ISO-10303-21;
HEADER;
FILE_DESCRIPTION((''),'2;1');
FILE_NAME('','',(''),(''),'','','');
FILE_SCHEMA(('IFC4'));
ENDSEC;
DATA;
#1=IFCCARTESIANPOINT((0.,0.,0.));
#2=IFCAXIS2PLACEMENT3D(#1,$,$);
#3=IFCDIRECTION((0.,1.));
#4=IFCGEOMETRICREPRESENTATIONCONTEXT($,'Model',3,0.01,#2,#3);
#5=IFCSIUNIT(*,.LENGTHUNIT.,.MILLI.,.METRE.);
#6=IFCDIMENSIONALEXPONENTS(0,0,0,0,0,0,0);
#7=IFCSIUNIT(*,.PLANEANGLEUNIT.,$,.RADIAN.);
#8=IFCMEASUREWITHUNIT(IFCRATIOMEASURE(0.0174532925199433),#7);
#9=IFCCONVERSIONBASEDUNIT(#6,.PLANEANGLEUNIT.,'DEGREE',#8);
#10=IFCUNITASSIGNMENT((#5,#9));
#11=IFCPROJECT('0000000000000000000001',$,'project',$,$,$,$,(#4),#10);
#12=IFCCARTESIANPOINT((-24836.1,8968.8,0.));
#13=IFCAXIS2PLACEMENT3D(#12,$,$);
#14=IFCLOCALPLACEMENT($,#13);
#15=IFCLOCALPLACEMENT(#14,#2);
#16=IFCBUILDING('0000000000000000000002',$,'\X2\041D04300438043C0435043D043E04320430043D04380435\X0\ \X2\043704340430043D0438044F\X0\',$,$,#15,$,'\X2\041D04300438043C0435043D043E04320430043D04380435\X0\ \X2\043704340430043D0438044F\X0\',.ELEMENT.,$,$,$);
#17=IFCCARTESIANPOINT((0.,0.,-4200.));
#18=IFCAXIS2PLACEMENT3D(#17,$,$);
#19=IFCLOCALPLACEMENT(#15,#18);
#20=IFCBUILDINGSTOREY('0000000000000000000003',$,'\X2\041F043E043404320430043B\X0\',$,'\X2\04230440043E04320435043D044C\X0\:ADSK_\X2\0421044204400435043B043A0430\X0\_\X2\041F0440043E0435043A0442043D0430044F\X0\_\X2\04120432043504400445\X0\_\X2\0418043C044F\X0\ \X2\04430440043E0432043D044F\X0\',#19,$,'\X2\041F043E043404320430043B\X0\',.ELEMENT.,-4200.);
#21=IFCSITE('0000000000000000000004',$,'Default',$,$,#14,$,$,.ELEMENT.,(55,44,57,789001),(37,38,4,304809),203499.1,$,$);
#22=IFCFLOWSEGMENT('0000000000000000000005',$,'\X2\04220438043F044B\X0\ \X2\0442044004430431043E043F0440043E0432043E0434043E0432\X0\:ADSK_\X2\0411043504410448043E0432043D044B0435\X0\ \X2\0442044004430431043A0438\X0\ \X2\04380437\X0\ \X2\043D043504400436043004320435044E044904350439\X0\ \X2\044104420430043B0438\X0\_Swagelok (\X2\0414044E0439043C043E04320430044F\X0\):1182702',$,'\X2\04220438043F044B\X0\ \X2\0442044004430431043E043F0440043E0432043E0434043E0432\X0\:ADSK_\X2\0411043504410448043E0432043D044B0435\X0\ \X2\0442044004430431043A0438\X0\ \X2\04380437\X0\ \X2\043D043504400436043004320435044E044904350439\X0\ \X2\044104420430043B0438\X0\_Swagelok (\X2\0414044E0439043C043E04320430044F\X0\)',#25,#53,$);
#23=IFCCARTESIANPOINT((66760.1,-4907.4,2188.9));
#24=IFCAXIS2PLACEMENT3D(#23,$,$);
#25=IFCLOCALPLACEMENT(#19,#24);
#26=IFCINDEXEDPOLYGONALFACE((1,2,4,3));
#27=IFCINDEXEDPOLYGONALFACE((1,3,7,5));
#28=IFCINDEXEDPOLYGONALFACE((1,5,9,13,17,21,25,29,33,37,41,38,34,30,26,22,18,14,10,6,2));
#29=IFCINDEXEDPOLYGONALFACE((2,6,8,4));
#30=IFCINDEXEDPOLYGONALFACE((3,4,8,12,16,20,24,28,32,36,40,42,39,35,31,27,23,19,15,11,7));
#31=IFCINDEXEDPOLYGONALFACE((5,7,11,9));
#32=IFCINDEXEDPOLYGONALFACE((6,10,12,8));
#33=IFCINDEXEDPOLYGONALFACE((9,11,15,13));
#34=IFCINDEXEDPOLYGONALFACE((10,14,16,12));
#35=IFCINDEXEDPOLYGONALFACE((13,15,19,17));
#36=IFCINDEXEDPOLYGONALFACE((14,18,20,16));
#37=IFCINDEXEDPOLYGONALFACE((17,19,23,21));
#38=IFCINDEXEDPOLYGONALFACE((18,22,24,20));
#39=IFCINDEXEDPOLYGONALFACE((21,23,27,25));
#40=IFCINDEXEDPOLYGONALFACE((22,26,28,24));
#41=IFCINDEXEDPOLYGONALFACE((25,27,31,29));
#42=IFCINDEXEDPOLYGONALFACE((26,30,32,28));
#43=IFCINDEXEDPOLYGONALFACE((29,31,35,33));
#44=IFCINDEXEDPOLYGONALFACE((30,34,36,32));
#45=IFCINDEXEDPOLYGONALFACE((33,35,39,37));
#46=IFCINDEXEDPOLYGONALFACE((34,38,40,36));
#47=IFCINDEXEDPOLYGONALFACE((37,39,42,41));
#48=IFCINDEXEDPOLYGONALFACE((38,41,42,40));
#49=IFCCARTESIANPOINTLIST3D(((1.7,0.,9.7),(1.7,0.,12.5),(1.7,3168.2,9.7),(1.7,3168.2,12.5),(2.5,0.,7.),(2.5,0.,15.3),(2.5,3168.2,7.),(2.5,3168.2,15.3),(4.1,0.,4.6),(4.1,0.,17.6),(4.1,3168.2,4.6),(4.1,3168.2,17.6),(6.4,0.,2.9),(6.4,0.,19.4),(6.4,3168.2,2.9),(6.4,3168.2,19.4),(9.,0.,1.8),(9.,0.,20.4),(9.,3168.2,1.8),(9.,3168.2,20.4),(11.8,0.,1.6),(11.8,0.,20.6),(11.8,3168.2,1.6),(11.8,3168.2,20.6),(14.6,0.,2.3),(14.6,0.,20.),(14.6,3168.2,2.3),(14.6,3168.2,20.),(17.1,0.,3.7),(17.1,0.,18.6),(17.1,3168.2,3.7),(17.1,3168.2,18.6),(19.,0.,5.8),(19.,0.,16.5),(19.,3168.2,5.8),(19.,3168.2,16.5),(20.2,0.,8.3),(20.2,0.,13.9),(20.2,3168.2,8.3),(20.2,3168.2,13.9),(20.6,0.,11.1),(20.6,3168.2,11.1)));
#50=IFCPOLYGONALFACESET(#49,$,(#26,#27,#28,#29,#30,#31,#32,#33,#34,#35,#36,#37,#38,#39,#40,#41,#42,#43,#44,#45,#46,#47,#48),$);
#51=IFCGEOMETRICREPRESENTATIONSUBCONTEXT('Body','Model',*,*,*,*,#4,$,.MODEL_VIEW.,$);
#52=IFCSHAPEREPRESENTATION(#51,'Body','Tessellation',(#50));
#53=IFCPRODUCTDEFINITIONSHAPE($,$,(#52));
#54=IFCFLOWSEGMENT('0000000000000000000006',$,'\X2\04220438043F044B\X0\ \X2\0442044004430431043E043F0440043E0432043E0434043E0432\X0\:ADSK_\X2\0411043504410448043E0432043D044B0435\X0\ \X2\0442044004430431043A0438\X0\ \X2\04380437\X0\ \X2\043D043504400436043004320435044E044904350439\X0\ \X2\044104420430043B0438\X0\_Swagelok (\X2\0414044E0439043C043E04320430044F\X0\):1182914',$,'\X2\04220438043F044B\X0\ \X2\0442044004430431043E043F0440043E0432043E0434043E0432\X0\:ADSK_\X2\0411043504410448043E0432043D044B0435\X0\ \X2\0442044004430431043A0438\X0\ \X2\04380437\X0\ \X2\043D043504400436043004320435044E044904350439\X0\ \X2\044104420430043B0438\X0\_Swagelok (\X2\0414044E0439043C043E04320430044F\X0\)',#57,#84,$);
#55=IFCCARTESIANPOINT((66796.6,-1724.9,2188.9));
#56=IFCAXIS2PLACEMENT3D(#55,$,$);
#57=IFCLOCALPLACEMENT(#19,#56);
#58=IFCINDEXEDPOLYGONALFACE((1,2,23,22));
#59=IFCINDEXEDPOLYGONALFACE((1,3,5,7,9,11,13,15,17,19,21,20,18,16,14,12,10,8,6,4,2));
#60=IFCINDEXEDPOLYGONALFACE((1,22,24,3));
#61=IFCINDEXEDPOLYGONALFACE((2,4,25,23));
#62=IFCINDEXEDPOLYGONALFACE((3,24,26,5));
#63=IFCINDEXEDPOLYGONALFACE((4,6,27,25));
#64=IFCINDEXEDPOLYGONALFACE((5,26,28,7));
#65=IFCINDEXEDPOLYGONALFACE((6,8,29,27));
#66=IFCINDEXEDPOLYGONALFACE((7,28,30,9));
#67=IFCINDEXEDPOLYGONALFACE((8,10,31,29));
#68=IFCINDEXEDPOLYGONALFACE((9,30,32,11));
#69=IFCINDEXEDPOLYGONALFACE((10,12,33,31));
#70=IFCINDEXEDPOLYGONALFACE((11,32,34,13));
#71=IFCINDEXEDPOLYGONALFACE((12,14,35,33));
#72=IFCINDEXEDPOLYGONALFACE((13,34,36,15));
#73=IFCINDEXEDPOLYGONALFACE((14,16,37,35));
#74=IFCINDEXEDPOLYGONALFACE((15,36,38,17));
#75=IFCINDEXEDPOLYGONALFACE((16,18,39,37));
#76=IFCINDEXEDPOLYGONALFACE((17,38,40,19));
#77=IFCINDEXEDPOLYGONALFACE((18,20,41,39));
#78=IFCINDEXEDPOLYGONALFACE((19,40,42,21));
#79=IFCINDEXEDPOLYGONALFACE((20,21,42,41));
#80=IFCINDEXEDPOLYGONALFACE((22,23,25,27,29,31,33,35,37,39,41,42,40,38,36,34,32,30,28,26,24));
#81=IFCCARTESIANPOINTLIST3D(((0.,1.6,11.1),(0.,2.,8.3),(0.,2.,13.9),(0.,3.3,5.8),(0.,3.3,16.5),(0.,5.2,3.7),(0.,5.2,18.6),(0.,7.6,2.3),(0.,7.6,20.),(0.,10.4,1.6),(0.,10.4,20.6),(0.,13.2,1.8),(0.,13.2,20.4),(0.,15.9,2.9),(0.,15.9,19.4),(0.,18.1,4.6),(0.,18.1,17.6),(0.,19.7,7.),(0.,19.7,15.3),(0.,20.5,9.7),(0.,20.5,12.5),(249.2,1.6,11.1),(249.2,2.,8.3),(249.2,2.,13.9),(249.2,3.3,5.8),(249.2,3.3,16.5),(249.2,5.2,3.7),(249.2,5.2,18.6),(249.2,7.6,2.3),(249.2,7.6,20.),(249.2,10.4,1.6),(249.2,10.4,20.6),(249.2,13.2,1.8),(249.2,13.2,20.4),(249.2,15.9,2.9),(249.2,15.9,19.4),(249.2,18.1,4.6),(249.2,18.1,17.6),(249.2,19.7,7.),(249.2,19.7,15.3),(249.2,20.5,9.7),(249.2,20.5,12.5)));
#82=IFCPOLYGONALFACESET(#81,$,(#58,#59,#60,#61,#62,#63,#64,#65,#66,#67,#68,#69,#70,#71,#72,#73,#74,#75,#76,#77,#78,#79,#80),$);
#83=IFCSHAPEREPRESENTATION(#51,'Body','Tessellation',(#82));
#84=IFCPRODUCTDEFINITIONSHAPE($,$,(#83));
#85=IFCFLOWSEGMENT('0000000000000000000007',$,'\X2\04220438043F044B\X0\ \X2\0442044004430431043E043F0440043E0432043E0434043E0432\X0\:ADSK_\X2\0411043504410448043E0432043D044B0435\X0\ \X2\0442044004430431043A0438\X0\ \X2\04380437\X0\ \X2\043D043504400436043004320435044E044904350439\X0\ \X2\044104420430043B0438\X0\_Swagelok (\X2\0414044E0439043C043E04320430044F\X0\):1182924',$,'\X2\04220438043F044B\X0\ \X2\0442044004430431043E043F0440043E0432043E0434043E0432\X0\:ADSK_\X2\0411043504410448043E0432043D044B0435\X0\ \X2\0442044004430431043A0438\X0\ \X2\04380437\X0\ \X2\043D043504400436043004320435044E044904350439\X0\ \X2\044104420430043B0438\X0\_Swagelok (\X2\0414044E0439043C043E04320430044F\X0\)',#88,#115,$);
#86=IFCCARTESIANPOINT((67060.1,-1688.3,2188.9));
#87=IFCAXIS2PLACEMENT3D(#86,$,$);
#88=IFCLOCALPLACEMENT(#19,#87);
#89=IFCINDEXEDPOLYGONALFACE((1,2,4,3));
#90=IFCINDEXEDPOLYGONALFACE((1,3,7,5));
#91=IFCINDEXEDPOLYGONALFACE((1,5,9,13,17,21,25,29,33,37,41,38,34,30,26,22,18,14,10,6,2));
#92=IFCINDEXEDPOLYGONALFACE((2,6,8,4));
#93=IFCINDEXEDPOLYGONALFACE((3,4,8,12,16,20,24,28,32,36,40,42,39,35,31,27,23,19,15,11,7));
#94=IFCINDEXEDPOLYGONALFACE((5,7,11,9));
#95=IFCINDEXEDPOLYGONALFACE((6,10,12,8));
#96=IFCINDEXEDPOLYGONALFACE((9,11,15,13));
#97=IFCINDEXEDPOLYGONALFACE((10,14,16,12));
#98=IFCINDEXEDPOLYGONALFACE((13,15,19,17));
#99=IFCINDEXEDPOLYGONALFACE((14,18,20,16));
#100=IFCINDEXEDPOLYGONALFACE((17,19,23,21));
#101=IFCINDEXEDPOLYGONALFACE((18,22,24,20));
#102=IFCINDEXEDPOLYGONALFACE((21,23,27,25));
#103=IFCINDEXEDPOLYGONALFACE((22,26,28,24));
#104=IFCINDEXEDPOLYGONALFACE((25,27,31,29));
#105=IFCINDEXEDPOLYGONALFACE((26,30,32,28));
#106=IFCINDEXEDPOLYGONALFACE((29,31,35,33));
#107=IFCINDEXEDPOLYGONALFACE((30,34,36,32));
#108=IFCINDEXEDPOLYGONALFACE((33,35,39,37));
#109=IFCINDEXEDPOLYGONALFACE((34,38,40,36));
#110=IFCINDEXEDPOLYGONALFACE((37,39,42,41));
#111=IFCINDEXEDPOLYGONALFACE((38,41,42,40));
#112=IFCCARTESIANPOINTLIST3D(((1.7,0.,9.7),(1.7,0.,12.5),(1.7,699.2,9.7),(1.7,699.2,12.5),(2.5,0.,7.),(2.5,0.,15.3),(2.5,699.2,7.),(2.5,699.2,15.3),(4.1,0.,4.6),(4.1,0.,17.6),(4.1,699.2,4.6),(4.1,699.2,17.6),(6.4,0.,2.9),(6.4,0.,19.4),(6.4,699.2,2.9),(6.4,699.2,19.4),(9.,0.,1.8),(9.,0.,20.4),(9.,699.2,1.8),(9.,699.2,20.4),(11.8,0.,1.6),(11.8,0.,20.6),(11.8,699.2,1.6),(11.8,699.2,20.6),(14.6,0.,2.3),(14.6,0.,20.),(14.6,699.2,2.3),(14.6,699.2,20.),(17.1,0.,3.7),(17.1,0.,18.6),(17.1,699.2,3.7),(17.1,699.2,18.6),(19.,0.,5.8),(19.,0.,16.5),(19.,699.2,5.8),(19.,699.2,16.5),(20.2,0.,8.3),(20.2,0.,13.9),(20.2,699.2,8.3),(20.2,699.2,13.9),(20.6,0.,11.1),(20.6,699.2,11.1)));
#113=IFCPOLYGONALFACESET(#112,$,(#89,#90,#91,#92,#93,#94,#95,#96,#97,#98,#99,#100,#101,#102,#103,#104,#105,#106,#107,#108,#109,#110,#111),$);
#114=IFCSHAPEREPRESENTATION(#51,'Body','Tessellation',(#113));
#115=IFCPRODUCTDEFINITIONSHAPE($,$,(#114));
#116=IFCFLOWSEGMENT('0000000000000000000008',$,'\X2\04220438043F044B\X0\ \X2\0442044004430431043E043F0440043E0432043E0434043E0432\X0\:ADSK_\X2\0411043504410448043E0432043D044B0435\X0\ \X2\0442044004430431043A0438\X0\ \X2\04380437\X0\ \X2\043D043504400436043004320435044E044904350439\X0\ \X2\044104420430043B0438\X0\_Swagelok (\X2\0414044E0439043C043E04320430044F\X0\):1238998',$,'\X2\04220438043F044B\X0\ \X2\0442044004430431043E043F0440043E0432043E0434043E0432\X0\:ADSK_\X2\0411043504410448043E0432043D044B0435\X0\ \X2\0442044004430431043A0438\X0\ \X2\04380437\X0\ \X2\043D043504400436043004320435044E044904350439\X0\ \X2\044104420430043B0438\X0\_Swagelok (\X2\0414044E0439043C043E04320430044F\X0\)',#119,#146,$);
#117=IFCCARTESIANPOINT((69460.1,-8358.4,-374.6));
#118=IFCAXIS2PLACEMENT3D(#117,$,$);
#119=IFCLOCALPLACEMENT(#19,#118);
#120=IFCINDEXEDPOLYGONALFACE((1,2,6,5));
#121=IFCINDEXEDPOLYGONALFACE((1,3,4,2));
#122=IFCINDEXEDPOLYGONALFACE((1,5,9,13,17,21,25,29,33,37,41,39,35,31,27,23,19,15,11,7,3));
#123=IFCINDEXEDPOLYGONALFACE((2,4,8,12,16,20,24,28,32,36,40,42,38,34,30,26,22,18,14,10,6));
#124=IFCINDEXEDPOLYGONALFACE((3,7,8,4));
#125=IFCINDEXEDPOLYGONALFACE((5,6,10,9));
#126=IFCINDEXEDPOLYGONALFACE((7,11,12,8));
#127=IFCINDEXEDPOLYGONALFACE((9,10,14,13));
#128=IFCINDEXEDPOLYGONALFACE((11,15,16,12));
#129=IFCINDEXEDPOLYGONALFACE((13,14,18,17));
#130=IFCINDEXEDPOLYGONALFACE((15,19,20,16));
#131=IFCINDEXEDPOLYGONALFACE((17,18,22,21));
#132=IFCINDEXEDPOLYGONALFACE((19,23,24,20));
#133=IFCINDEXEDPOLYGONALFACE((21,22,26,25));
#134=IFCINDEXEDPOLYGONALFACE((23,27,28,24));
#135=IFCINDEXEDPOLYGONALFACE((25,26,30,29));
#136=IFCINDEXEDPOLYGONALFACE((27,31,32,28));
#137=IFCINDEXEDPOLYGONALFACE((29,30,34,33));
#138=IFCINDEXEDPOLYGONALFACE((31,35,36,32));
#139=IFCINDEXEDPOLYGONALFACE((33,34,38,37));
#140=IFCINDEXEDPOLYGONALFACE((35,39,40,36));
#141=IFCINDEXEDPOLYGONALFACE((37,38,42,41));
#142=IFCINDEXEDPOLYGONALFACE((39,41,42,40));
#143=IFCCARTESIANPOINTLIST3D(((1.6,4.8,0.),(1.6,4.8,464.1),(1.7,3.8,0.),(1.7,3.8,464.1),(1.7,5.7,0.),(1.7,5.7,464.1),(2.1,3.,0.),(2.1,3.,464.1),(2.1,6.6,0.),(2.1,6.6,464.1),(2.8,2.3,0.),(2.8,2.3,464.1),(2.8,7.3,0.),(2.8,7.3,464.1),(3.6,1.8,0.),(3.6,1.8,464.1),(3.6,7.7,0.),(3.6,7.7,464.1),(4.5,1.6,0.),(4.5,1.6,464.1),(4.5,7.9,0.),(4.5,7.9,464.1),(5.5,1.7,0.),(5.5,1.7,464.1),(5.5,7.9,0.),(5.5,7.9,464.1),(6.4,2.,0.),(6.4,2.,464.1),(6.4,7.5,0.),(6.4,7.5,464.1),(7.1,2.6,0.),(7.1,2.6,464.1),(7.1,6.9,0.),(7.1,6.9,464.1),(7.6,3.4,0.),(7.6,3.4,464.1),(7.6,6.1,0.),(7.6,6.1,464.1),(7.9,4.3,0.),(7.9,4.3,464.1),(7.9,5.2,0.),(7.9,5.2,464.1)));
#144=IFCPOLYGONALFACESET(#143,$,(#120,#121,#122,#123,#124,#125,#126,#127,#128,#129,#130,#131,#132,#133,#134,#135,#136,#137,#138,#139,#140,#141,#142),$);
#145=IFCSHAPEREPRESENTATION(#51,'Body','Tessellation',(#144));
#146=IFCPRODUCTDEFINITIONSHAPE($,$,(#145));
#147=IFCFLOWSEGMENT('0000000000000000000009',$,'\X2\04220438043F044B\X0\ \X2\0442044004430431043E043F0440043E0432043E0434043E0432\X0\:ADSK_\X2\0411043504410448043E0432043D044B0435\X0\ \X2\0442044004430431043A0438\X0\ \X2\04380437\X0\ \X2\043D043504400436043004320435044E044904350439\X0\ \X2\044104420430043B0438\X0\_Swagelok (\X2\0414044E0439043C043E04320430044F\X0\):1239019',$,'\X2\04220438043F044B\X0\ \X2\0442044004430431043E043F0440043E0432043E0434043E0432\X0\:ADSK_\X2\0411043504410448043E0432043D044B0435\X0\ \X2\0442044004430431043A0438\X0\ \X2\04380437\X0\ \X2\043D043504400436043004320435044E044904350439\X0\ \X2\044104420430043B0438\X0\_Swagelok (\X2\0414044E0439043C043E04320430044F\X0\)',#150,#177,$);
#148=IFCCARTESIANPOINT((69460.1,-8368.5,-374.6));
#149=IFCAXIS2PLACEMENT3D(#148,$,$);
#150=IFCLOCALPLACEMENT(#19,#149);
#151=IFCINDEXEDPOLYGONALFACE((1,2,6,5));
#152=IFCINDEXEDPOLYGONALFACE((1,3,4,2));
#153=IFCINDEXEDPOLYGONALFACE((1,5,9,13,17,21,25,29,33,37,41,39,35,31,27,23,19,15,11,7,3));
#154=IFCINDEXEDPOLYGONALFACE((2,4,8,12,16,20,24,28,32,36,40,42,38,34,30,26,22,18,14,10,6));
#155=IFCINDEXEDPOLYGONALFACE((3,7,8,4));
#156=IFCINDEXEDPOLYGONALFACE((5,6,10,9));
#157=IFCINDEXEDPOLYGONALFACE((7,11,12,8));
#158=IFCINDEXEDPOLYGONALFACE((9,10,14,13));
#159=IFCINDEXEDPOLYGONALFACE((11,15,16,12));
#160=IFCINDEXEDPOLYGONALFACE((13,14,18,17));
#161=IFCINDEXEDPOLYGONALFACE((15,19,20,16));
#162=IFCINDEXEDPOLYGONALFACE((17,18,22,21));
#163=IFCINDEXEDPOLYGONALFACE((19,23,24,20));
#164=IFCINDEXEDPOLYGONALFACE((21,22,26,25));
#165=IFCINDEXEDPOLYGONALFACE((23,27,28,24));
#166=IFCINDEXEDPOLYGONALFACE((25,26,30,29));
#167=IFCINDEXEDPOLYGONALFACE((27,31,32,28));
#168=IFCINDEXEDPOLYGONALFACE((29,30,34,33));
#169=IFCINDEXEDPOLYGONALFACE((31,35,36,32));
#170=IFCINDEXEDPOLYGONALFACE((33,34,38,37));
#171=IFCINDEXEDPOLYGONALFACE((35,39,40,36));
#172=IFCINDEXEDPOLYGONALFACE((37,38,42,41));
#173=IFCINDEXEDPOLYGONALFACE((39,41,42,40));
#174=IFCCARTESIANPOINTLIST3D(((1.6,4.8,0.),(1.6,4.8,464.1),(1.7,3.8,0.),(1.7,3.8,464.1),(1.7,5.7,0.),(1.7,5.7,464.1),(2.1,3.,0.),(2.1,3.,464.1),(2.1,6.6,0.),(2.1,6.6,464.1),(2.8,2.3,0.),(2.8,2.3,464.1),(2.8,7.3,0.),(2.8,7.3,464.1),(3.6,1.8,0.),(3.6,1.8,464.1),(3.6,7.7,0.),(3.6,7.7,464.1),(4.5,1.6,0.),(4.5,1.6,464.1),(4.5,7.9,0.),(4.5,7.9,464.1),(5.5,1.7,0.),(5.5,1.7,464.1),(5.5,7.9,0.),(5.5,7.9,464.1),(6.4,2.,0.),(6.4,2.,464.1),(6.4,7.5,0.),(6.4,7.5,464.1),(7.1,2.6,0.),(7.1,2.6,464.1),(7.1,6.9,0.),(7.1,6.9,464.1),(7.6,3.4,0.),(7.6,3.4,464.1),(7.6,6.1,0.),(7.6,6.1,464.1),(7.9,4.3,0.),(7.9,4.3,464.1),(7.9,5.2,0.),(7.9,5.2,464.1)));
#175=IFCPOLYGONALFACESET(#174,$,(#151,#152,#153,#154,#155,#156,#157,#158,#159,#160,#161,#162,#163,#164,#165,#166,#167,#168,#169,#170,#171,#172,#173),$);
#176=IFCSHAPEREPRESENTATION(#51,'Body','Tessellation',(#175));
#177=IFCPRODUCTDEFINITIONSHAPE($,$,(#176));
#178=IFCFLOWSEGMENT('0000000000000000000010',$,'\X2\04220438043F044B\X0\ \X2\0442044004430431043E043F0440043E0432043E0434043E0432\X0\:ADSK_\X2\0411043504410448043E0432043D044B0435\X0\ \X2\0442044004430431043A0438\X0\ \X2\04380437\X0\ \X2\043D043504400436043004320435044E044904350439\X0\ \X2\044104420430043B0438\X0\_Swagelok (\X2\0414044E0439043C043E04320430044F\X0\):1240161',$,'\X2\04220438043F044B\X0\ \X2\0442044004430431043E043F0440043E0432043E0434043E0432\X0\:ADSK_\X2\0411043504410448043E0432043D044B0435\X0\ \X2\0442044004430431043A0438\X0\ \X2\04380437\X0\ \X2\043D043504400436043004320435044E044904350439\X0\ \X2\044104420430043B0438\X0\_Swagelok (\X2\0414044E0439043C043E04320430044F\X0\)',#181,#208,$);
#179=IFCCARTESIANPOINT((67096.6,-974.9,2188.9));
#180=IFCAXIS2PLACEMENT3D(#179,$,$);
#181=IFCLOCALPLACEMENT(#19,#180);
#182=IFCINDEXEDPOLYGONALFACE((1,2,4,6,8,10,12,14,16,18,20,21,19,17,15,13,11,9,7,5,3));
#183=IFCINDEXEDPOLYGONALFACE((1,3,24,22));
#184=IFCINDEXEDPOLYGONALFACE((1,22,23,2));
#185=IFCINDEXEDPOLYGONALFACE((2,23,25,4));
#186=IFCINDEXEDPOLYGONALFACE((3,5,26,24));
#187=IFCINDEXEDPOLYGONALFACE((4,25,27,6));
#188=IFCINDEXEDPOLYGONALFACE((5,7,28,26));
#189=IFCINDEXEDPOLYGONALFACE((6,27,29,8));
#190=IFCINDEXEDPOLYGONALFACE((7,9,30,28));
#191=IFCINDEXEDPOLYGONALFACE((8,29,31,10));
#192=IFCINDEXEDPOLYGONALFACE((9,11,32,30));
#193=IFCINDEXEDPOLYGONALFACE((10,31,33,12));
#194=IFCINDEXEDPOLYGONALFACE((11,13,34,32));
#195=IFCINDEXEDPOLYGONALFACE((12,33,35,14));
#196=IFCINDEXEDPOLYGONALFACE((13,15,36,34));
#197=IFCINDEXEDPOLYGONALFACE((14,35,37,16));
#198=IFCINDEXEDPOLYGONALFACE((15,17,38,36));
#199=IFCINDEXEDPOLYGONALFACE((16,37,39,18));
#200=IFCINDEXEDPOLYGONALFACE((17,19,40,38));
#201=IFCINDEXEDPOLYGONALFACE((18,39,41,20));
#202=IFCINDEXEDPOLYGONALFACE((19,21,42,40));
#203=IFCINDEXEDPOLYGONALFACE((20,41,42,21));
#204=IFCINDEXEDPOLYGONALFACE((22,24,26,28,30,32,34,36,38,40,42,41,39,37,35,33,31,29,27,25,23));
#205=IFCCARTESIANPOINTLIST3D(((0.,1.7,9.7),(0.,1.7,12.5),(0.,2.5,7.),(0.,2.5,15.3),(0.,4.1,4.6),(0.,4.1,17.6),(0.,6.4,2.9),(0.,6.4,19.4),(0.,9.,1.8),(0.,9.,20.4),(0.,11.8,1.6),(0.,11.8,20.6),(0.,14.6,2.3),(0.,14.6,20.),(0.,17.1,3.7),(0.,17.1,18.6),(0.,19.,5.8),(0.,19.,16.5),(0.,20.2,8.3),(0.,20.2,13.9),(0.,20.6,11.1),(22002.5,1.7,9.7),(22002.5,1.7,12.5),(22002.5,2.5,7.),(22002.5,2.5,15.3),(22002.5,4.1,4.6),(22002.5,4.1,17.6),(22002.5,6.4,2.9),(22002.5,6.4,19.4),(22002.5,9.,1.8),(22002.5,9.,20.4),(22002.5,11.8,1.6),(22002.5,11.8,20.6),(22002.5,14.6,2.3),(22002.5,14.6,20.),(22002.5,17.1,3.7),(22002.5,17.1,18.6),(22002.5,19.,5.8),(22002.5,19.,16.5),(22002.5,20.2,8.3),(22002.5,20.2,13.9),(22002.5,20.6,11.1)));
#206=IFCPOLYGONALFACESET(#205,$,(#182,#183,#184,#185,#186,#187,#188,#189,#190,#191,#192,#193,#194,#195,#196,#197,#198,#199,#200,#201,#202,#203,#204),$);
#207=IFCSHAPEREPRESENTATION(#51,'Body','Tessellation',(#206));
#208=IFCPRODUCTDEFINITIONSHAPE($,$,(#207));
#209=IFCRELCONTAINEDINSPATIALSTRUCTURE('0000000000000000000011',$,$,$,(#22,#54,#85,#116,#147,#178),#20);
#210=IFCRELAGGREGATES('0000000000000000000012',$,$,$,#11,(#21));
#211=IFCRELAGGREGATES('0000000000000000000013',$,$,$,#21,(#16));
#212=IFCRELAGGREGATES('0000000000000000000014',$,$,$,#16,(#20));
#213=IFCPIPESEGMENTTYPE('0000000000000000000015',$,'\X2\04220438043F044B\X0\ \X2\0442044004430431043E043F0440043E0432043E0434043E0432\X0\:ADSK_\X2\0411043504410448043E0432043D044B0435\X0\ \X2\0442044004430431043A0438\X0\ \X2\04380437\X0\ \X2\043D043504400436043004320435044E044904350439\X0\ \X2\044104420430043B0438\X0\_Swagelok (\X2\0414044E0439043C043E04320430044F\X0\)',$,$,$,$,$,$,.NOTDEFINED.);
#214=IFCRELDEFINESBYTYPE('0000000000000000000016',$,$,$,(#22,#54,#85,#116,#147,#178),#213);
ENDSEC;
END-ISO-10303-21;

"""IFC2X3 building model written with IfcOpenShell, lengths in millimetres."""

from ifc_helpers import new_model, entity, si_unit, converted_unit, direction, frame, origin, origin_2d_with_axis, place, context, subcontext, project, spatial, circle, extrude, type_object, element, save


model = new_model("IFC2X3")

# Units and contexts
model_context = context("Model", 3, precision=0.01, world=origin(), true_north=direction((0.0, 1.0)))
body_context = subcontext(model_context, "Body", "Model", "MODEL_VIEW")
ifc_project = project(units=[si_unit("LENGTHUNIT", "METRE", prefix="MILLI"), converted_unit("PLANEANGLEUNIT", "DEGREE", entity("IfcRatioMeasure", 0.0174532925199433), si_unit("PLANEANGLEUNIT", "RADIAN"), dimensions=[0, 0, 0, 0, 0, 0, 0])], contexts=[model_context])

# Site, building, storey
site_placement = place(None, frame((-24836.1, 8968.8, 0.0)))
site = spatial("IfcSite", under=ifc_project, at=site_placement, Name="Default", CompositionType="ELEMENT", RefLatitude=(55, 44, 57, 789001), RefLongitude=(37, 38, 4, 304809), RefElevation=203499.1)
building_placement = place(site_placement, origin())
building = spatial("IfcBuilding", under=site, at=building_placement, Name="Наименование здания", LongName="Наименование здания", CompositionType="ELEMENT")
storey_placement = place(building_placement, frame((0.0, 0.0, -4200.0)))
storey = spatial("IfcBuildingStorey", under=building, at=storey_placement, Name="Подвал", ObjectType="Уровень:ADSK_Стрелка_Проектная_Вверх_Имя уровня", LongName="Подвал", CompositionType="ELEMENT", Elevation=-4200.0)

# Flow segments
pipe_segment_type_1 = type_object("IfcPipeSegmentType", Name="Типы трубопроводов:ADSK_Бесшовные трубки из нержавеющей стали_Swagelok (Дюймовая)", PredefinedType="NOTDEFINED")
flow_segment_1_placement = place(storey_placement, frame((66760.1, -4907.4, 2188.9)))
element("IfcFlowSegment", 1, at=flow_segment_1_placement, inside=storey, type_object=pipe_segment_type_1, Name="Типы трубопроводов:ADSK_Бесшовные трубки из нержавеющей стали_Swagelok (Дюймовая):1182702", ObjectType="Типы трубопроводов:ADSK_Бесшовные трубки из нержавеющей стали_Swagelok (Дюймовая)", context=body_context, shape_type="SweptSolid", body=[
    extrude(circle(Radius=9.5, at=origin_2d_with_axis()), frame((11.1, 0.0, 11.1), z_axis=(0.0, 1.0, 0.0), x_axis=(1.0, 0.0, 0.0)), (0.0, 0.0, 1.0), 3168.2),
])
flow_segment_2_placement = place(storey_placement, frame((66796.6, -1724.9, 2188.9)))
element("IfcFlowSegment", 2, at=flow_segment_2_placement, inside=storey, type_object=pipe_segment_type_1, Name="Типы трубопроводов:ADSK_Бесшовные трубки из нержавеющей стали_Swagelok (Дюймовая):1182914", ObjectType="Типы трубопроводов:ADSK_Бесшовные трубки из нержавеющей стали_Swagelok (Дюймовая)", context=body_context, shape_type="SweptSolid", body=[
    extrude(circle(Radius=9.5, at=origin_2d_with_axis()), frame((0.0, 11.1, 11.1), z_axis=(1.0, 0.0, 0.0), x_axis=(0.0, -1.0, 0.0)), (0.0, 0.0, 1.0), 249.2),
])
flow_segment_3_placement = place(storey_placement, frame((67060.1, -1688.3, 2188.9)))
element("IfcFlowSegment", 3, at=flow_segment_3_placement, inside=storey, type_object=pipe_segment_type_1, Name="Типы трубопроводов:ADSK_Бесшовные трубки из нержавеющей стали_Swagelok (Дюймовая):1182924", ObjectType="Типы трубопроводов:ADSK_Бесшовные трубки из нержавеющей стали_Swagelok (Дюймовая)", context=body_context, shape_type="SweptSolid", body=[
    extrude(circle(Radius=9.5, at=origin_2d_with_axis()), frame((11.1, 0.0, 11.1), z_axis=(0.0, 1.0, 0.0), x_axis=(1.0, 0.0, 0.0)), (0.0, 0.0, 1.0), 699.2),
])
flow_segment_4_placement = place(storey_placement, frame((69460.1, -8358.4, -374.6)))
element("IfcFlowSegment", 4, at=flow_segment_4_placement, inside=storey, type_object=pipe_segment_type_1, Name="Типы трубопроводов:ADSK_Бесшовные трубки из нержавеющей стали_Swagelok (Дюймовая):1238998", ObjectType="Типы трубопроводов:ADSK_Бесшовные трубки из нержавеющей стали_Swagelok (Дюймовая)", context=body_context, shape_type="SweptSolid", body=[
    extrude(circle(Radius=3.2, at=origin_2d_with_axis()), frame((4.8, 4.8, 0.0), z_axis=(0.0, 0.0, 1.0), x_axis=(-1.0, 0.0, 0.0)), (0.0, 0.0, 1.0), 464.1),
])
flow_segment_5_placement = place(storey_placement, frame((69460.1, -8368.5, -374.6)))
element("IfcFlowSegment", 5, at=flow_segment_5_placement, inside=storey, type_object=pipe_segment_type_1, Name="Типы трубопроводов:ADSK_Бесшовные трубки из нержавеющей стали_Swagelok (Дюймовая):1239019", ObjectType="Типы трубопроводов:ADSK_Бесшовные трубки из нержавеющей стали_Swagelok (Дюймовая)", context=body_context, shape_type="SweptSolid", body=[
    extrude(circle(Radius=3.2, at=origin_2d_with_axis()), frame((4.8, 4.8, 0.0), z_axis=(0.0, 0.0, 1.0), x_axis=(-1.0, 0.0, 0.0)), (0.0, 0.0, 1.0), 464.1),
])
flow_segment_6_placement = place(storey_placement, frame((67096.6, -974.9, 2188.9)))
element("IfcFlowSegment", 6, at=flow_segment_6_placement, inside=storey, type_object=pipe_segment_type_1, Name="Типы трубопроводов:ADSK_Бесшовные трубки из нержавеющей стали_Swagelok (Дюймовая):1240161", ObjectType="Типы трубопроводов:ADSK_Бесшовные трубки из нержавеющей стали_Swagelok (Дюймовая)", context=body_context, shape_type="SweptSolid", body=[
    extrude(circle(Radius=9.5, at=origin_2d_with_axis()), frame((0.0, 11.1, 11.1), z_axis=(1.0, 0.0, 0.0), x_axis=(0.0, 1.0, 0.0)), (0.0, 0.0, 1.0), 22002.5),
])

save(model, "model.ifc")
